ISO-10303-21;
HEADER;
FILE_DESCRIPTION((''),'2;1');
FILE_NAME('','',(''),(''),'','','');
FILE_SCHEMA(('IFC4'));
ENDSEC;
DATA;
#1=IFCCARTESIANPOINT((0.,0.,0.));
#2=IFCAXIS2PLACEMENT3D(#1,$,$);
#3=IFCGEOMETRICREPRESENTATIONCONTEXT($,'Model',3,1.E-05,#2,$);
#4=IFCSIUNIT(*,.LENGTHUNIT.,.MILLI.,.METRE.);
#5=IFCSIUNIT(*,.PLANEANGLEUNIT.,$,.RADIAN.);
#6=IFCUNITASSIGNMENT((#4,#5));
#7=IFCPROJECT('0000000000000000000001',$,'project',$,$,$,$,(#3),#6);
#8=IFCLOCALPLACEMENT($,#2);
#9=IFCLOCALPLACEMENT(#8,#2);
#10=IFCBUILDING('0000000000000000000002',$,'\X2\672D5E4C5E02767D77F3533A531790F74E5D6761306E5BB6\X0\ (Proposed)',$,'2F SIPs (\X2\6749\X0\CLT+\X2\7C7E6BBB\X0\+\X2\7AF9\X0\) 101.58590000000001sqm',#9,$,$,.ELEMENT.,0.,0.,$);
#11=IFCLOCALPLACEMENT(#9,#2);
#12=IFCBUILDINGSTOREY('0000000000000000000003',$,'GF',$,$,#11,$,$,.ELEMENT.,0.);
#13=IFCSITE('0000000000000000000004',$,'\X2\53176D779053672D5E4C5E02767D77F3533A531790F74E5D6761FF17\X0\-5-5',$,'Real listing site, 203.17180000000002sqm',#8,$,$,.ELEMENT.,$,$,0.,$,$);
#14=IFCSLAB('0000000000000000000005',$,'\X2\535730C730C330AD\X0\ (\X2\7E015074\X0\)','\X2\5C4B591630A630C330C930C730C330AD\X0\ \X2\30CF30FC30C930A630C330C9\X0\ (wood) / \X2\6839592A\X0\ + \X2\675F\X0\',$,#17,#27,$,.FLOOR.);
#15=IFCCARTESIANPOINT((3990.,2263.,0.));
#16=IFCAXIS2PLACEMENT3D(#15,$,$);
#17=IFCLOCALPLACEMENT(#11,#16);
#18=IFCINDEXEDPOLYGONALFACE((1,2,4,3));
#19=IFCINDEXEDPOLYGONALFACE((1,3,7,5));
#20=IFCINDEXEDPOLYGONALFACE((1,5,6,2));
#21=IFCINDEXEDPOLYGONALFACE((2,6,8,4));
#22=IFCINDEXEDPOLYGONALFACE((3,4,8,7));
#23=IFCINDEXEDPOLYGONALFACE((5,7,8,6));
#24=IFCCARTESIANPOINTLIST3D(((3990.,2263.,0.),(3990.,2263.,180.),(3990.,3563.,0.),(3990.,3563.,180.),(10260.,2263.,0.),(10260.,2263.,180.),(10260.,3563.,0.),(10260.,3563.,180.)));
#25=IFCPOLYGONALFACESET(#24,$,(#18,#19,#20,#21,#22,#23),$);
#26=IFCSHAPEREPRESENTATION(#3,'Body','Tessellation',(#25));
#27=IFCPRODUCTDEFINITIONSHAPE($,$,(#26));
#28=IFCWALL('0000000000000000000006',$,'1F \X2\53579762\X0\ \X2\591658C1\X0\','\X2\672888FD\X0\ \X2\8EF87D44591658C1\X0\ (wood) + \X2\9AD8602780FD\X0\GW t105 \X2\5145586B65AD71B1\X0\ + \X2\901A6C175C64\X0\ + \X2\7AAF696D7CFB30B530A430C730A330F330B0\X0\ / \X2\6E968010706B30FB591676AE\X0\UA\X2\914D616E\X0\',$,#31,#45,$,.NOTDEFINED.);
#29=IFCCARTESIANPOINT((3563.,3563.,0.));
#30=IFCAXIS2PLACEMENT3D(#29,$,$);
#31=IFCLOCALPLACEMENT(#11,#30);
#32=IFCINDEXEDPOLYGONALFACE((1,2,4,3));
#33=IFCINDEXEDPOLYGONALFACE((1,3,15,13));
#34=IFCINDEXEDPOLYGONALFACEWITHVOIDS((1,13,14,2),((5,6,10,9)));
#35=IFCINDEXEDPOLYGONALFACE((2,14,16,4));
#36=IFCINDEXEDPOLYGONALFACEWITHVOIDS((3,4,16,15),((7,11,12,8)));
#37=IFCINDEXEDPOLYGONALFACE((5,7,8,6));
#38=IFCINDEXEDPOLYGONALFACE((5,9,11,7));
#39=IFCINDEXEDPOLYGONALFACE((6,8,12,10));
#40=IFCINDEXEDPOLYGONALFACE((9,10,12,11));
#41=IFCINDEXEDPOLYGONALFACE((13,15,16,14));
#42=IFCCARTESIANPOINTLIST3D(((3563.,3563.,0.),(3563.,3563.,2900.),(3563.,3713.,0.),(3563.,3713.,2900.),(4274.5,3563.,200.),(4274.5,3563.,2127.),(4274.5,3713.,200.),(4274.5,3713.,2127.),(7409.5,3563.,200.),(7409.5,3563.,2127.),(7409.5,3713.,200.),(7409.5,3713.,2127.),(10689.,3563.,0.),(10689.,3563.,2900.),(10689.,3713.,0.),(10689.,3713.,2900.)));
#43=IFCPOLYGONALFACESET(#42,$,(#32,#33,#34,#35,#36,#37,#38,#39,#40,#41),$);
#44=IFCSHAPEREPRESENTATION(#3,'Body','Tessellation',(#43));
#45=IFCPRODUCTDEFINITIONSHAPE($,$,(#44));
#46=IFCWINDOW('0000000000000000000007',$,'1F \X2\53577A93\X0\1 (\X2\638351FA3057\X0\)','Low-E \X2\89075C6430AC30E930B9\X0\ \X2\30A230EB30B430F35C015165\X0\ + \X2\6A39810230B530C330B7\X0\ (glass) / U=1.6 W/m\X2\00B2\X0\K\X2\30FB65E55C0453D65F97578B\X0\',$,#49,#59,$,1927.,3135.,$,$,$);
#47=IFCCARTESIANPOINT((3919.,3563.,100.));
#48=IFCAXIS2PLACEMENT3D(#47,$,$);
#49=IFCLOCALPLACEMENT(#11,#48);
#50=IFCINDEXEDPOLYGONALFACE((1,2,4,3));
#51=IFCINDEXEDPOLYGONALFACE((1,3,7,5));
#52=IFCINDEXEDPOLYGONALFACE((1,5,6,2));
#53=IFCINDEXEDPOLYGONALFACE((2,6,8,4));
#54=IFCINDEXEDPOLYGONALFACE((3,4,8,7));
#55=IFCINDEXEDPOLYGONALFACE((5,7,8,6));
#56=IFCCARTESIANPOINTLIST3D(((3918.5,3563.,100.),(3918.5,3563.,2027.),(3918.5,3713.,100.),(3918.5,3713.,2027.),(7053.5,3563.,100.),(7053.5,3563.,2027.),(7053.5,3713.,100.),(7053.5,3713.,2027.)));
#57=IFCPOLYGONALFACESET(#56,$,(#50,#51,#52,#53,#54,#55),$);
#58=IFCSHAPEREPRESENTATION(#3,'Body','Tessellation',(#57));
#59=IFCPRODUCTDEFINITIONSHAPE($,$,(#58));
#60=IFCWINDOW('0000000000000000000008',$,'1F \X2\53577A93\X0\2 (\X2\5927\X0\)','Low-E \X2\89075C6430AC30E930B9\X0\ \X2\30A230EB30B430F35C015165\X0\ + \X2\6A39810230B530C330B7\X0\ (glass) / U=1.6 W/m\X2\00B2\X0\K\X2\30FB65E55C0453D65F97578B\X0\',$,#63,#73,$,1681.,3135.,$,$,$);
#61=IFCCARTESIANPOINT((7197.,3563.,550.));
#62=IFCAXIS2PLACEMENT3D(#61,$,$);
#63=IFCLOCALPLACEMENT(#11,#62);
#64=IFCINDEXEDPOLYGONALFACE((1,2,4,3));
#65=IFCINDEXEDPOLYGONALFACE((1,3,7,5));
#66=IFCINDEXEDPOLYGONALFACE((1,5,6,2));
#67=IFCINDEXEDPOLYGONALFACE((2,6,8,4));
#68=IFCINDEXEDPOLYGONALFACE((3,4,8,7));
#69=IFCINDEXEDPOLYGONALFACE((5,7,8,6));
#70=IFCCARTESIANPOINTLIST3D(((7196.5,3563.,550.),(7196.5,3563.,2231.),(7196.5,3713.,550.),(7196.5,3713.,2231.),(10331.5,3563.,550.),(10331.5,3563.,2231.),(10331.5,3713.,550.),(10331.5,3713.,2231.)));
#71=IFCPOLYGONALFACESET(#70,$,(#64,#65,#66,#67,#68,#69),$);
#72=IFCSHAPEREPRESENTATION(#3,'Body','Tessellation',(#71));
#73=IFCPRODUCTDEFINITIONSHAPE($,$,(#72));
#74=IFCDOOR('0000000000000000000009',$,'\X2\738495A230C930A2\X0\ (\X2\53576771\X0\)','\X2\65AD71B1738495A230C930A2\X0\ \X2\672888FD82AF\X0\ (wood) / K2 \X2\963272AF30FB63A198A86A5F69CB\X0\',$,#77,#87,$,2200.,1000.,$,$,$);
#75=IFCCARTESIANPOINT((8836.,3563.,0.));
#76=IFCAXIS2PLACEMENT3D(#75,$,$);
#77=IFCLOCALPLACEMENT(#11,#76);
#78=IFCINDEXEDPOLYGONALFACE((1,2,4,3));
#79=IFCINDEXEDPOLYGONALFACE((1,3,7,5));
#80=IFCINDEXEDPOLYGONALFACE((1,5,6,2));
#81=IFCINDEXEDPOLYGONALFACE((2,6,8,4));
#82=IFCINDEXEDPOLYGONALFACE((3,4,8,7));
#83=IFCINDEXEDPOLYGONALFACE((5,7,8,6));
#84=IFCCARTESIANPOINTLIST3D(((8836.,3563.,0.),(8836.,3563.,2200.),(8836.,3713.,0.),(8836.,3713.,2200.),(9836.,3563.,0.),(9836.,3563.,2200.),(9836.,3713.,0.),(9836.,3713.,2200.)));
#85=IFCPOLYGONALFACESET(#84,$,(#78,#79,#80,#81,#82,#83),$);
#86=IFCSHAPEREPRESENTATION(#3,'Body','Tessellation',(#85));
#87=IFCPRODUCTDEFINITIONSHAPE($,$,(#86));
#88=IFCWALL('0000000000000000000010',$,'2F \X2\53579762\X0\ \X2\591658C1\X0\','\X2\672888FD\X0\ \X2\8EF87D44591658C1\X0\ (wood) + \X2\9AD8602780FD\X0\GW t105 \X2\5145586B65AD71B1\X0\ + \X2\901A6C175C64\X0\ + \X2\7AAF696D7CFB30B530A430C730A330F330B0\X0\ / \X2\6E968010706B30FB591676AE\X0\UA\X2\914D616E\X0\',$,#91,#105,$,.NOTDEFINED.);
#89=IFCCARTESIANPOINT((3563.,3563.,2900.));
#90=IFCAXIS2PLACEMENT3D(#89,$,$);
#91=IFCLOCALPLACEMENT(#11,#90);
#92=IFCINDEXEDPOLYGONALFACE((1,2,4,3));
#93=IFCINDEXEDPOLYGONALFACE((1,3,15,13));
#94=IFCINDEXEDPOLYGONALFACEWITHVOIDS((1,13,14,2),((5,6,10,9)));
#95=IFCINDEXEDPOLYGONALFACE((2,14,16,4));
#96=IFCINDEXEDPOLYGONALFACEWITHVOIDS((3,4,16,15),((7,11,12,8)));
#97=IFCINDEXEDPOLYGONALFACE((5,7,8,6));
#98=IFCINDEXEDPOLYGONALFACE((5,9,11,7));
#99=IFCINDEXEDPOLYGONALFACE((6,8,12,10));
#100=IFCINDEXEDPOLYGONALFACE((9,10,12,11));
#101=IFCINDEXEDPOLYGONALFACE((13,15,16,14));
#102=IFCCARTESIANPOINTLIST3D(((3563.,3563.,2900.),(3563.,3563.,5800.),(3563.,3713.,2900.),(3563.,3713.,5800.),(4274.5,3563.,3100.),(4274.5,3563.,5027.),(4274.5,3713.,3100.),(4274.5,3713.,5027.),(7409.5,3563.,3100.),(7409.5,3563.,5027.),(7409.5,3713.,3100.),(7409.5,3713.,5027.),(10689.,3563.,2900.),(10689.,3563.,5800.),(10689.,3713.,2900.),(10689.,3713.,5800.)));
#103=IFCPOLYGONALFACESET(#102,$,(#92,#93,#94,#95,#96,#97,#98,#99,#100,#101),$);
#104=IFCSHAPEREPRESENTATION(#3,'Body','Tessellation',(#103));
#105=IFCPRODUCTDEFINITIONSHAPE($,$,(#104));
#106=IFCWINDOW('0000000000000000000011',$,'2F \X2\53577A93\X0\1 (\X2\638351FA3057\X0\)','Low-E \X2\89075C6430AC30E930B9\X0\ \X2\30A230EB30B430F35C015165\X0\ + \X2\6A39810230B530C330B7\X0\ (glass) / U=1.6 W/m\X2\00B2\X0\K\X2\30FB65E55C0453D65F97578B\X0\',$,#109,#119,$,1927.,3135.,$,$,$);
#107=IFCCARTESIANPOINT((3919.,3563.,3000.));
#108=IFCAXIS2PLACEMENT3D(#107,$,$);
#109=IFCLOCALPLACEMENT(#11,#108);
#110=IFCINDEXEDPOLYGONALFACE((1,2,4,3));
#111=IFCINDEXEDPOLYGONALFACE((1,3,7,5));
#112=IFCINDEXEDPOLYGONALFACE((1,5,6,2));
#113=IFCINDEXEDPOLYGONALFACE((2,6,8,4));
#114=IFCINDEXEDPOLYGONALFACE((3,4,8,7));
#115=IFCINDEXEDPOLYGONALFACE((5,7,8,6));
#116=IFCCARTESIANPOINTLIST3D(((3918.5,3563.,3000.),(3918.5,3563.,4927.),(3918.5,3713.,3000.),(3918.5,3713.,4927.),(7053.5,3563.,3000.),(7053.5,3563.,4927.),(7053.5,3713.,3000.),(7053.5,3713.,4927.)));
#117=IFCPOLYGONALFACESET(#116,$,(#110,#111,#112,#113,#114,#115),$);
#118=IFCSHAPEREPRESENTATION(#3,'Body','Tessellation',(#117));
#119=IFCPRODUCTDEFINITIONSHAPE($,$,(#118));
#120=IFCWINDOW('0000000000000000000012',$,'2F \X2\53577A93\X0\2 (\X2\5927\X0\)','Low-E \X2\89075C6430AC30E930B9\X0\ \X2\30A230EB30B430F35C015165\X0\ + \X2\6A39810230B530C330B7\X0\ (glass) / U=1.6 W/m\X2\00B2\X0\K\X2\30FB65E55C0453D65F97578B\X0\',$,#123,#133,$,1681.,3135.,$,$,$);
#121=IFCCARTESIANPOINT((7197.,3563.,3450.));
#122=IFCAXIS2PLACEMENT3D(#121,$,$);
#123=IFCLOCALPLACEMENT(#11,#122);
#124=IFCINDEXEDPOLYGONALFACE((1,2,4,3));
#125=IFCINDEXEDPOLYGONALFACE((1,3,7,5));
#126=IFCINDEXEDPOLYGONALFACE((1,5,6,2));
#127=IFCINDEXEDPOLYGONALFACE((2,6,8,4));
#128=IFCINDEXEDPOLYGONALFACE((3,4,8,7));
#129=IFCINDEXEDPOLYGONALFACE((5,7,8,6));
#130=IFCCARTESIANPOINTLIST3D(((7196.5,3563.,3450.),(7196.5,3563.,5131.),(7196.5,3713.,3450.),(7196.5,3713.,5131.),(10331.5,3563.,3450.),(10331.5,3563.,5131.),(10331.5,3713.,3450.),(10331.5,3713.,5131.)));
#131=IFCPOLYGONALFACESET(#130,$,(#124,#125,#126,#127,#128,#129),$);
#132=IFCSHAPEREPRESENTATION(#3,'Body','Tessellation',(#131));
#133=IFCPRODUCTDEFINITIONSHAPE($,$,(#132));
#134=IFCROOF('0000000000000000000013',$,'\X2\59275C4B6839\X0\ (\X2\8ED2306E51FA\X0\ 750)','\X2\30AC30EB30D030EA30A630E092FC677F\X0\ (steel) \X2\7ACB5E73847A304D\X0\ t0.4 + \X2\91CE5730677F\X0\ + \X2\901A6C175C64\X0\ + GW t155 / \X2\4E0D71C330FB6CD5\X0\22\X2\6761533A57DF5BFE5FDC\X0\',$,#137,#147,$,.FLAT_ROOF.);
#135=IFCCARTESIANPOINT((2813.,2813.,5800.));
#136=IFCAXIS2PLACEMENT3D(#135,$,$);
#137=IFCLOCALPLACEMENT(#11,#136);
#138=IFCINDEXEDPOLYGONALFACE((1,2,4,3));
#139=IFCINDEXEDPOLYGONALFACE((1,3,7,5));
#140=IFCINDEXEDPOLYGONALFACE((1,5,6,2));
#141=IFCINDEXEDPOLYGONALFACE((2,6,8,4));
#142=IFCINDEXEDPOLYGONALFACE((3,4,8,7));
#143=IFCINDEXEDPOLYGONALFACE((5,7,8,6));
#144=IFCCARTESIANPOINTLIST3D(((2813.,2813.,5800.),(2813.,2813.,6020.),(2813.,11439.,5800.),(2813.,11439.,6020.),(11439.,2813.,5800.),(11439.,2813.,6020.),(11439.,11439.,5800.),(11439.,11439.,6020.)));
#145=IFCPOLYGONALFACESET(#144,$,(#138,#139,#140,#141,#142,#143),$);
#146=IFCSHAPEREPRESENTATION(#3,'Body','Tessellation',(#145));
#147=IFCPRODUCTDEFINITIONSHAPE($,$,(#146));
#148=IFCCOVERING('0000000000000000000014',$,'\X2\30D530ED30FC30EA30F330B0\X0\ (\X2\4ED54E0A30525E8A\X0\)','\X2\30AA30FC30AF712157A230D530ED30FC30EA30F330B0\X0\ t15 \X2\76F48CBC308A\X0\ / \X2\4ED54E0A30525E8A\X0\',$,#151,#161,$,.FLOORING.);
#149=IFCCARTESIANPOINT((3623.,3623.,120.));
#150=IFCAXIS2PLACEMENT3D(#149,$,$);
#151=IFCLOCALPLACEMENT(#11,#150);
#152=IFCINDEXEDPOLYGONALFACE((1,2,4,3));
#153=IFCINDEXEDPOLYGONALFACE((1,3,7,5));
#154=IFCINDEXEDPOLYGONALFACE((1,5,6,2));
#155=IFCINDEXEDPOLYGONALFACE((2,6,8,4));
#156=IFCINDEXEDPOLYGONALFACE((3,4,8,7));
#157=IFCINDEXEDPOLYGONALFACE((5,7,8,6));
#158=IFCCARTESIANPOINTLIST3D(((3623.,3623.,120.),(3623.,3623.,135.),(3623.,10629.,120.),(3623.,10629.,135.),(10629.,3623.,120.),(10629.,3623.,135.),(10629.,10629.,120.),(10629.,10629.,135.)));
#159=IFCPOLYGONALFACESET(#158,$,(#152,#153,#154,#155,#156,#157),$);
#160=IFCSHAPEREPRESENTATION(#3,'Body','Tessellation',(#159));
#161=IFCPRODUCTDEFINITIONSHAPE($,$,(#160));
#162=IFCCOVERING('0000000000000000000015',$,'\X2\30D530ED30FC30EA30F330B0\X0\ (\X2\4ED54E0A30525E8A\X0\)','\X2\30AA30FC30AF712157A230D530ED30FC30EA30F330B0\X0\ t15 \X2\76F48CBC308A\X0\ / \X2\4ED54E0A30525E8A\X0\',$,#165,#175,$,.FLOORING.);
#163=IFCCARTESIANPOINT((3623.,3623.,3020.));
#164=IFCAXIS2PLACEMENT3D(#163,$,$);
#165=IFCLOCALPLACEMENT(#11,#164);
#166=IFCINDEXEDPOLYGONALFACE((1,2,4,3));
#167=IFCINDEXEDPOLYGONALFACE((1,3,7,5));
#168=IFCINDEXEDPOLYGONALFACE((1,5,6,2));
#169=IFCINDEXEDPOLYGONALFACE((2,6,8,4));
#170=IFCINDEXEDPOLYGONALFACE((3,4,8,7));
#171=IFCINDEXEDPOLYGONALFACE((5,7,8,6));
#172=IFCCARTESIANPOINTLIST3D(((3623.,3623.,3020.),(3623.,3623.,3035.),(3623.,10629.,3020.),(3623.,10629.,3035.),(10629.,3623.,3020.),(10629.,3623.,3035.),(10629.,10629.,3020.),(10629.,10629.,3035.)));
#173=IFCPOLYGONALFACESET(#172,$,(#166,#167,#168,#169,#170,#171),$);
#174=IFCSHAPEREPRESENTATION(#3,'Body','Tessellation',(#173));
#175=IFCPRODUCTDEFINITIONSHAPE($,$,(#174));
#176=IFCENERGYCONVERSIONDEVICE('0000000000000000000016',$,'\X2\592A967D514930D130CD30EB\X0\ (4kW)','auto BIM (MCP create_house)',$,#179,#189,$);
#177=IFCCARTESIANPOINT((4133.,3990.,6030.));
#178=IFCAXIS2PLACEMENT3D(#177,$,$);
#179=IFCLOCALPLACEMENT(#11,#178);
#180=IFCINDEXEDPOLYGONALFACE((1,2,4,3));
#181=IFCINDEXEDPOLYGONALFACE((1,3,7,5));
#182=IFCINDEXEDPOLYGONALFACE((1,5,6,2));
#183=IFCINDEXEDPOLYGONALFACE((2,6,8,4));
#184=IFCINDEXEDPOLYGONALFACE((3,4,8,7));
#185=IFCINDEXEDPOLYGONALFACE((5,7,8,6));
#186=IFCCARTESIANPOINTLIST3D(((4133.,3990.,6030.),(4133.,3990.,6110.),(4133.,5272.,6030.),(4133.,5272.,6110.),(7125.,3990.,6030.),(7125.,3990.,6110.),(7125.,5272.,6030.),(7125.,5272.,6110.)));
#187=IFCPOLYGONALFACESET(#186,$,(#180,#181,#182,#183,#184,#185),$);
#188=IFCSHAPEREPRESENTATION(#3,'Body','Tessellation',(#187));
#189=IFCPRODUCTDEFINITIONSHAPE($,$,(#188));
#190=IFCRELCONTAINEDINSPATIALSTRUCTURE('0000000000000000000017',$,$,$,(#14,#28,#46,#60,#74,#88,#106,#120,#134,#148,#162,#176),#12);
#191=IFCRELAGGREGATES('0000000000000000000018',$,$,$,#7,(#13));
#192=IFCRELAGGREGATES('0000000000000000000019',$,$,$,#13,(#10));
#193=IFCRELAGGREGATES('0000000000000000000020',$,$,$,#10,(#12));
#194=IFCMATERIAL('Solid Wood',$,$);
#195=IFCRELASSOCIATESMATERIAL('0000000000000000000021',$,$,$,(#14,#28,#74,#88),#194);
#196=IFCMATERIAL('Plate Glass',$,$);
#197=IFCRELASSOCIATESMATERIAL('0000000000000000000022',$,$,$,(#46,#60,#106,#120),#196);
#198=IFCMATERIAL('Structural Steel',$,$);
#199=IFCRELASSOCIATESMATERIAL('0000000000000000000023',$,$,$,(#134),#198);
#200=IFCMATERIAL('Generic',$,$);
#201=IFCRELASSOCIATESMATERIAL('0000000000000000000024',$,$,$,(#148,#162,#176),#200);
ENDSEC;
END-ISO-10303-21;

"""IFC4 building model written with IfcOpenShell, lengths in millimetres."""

from ifc_helpers import new_model, si_unit, frame, frame_2d, origin, place, context, project, spatial, rectangle, extrude, material, element, fill, save


model = new_model("IFC4")

# Units and contexts
model_context = context("Model", 3, precision=1e-05, world=origin())
ifc_project = project(units=[si_unit("LENGTHUNIT", "METRE", prefix="MILLI"), si_unit("PLANEANGLEUNIT", "RADIAN")], contexts=[model_context])

# Site, building, storey
site_placement = place(None, origin())
site = spatial("IfcSite", under=ifc_project, at=site_placement, Name="北海道札幌市白石区北郷九条７-5-5", ObjectType="Real listing site, 203.17180000000002sqm", CompositionType="ELEMENT", RefElevation=0.0)
building_placement = place(site_placement, origin())
building = spatial("IfcBuilding", under=site, at=building_placement, Name="札幌市白石区北郷九条の家 (Proposed)", ObjectType="2F SIPs (杉CLT+籾殻+竹) 101.58590000000001sqm", CompositionType="ELEMENT", ElevationOfRefHeight=0.0, ElevationOfTerrain=0.0)
storey_placement = place(building_placement, origin())
storey = spatial("IfcBuildingStorey", under=building, at=storey_placement, Name="GF", CompositionType="ELEMENT", Elevation=0.0)

# Slab
ifc_material_1 = material(Name="Solid Wood")
slab_1_placement = place(storey_placement, frame((3990.0, 2263.0, 0.0)))
element("IfcSlab", 1, at=slab_1_placement, inside=storey, material=ifc_material_1, Name="南デッキ (縁側)", Description="屋外ウッドデッキ ハードウッド (wood) / 根太 + 束", PredefinedType="FLOOR", context=model_context, shape_type="SweptSolid", body=[
    extrude(rectangle(XDim=6270.0, YDim=1300.0, at=frame_2d((3135.0, 650.0))), frame((3990.0, 2263.0, 0.0)), (0.0, 0.0, 1.0), 180.0),
])

# Wall, openings, windows, door
wall_1_placement = place(storey_placement, frame((3563.0, 3563.0, 0.0)))
wall_1 = element("IfcWall", 2, at=wall_1_placement, inside=storey, material=ifc_material_1, Name="1F 南面 外壁", Description="木製 軸組外壁 (wood) + 高性能GW t105 充填断熱 + 通気層 + 窯業系サイディング / 準耐火・外皮UA配慮", PredefinedType="NOTDEFINED", context=model_context, shape_type="SweptSolid", body=[
    extrude(rectangle(XDim=7126.0, YDim=150.0, at=frame_2d((3563.0, 75.0))), frame((3563.0, 3563.0, 0.0)), (0.0, 0.0, 1.0), 2900.0),
])
opening_1_placement = place(storey_placement, frame((3919.0, 3563.0, 100.0)))
opening_1 = element("IfcOpeningElement", 3, at=opening_1_placement, cuts=wall_1, PredefinedType="NOTDEFINED", context=model_context, shape_type="SweptSolid", body=[
    extrude(rectangle(XDim=3135.0, YDim=150.0, at=frame_2d((1567.0, 75.0))), frame((3919.0, 3563.0, 100.0)), (0.0, 0.0, 1.0), 1927.0),
])
opening_2_placement = place(storey_placement, frame((7197.0, 3563.0, 550.0)))
opening_2 = element("IfcOpeningElement", 4, at=opening_2_placement, cuts=wall_1, PredefinedType="NOTDEFINED", context=model_context, shape_type="SweptSolid", body=[
    extrude(rectangle(XDim=3135.0, YDim=150.0, at=frame_2d((1567.0, 75.0))), frame((7197.0, 3563.0, 550.0)), (0.0, 0.0, 1.0), 1681.0),
])
opening_3_placement = place(storey_placement, frame((8836.0, 3563.0, 0.0)))
opening_3 = element("IfcOpeningElement", 5, at=opening_3_placement, cuts=wall_1, PredefinedType="NOTDEFINED", context=model_context, shape_type="SweptSolid", body=[
    extrude(rectangle(XDim=1000.0, YDim=150.0, at=frame_2d((500.0, 75.0))), frame((8836.0, 3563.0, 0.0)), (0.0, 0.0, 1.0), 2200.0),
])
ifc_material_2 = material(Name="Plate Glass")
window_1_placement = place(storey_placement, frame((3919.0, 3563.0, 100.0)))
window_1 = element("IfcWindow", 6, at=window_1_placement, inside=storey, material=ifc_material_2, Name="1F 南窓1 (掃出し)", Description="Low-E 複層ガラス アルゴン封入 + 樹脂サッシ (glass) / U=1.6 W/m²K・日射取得型", OverallHeight=1927.0, OverallWidth=3135.0, context=model_context, shape_type="SweptSolid", body=[
    extrude(rectangle(XDim=3135.0, YDim=150.0, at=frame_2d((1567.0, 75.0))), frame((3919.0, 3563.0, 100.0)), (0.0, 0.0, 1.0), 1927.0),
])
fill(opening_1, window_1)
window_2_placement = place(storey_placement, frame((7197.0, 3563.0, 550.0)))
window_2 = element("IfcWindow", 7, at=window_2_placement, inside=storey, material=ifc_material_2, Name="1F 南窓2 (大)", Description="Low-E 複層ガラス アルゴン封入 + 樹脂サッシ (glass) / U=1.6 W/m²K・日射取得型", OverallHeight=1681.0, OverallWidth=3135.0, context=model_context, shape_type="SweptSolid", body=[
    extrude(rectangle(XDim=3135.0, YDim=150.0, at=frame_2d((1567.0, 75.0))), frame((7197.0, 3563.0, 550.0)), (0.0, 0.0, 1.0), 1681.0),
])
fill(opening_2, window_2)
door_placement = place(storey_placement, frame((8836.0, 3563.0, 0.0)))
door = element("IfcDoor", 8, at=door_placement, inside=storey, material=ifc_material_1, Name="玄関ドア (南東)", Description="断熱玄関ドア 木製芯 (wood) / K2 防犯・採風機構", OverallHeight=2200.0, OverallWidth=1000.0, context=model_context, shape_type="SweptSolid", body=[
    extrude(rectangle(XDim=1000.0, YDim=150.0, at=frame_2d((500.0, 75.0))), frame((8836.0, 3563.0, 0.0)), (0.0, 0.0, 1.0), 2200.0),
])
fill(opening_3, door)

# Wall, openings, windows
wall_2_placement = place(storey_placement, frame((3563.0, 3563.0, 2900.0)))
wall_2 = element("IfcWall", 9, at=wall_2_placement, inside=storey, material=ifc_material_1, Name="2F 南面 外壁", Description="木製 軸組外壁 (wood) + 高性能GW t105 充填断熱 + 通気層 + 窯業系サイディング / 準耐火・外皮UA配慮", PredefinedType="NOTDEFINED", context=model_context, shape_type="SweptSolid", body=[
    extrude(rectangle(XDim=7126.0, YDim=150.0, at=frame_2d((3563.0, 75.0))), frame((3563.0, 3563.0, 2900.0)), (0.0, 0.0, 1.0), 2900.0),
])
opening_4_placement = place(storey_placement, frame((3919.0, 3563.0, 3000.0)))
opening_4 = element("IfcOpeningElement", 10, at=opening_4_placement, cuts=wall_2, PredefinedType="NOTDEFINED", context=model_context, shape_type="SweptSolid", body=[
    extrude(rectangle(XDim=3135.0, YDim=150.0, at=frame_2d((1567.0, 75.0))), frame((3919.0, 3563.0, 3000.0)), (0.0, 0.0, 1.0), 1927.0),
])
opening_5_placement = place(storey_placement, frame((7197.0, 3563.0, 3450.0)))
opening_5 = element("IfcOpeningElement", 11, at=opening_5_placement, cuts=wall_2, PredefinedType="NOTDEFINED", context=model_context, shape_type="SweptSolid", body=[
    extrude(rectangle(XDim=3135.0, YDim=150.0, at=frame_2d((1567.0, 75.0))), frame((7197.0, 3563.0, 3450.0)), (0.0, 0.0, 1.0), 1681.0),
])
window_3_placement = place(storey_placement, frame((3919.0, 3563.0, 3000.0)))
window_3 = element("IfcWindow", 12, at=window_3_placement, inside=storey, material=ifc_material_2, Name="2F 南窓1 (掃出し)", Description="Low-E 複層ガラス アルゴン封入 + 樹脂サッシ (glass) / U=1.6 W/m²K・日射取得型", OverallHeight=1927.0, OverallWidth=3135.0, context=model_context, shape_type="SweptSolid", body=[
    extrude(rectangle(XDim=3135.0, YDim=150.0, at=frame_2d((1567.0, 75.0))), frame((3919.0, 3563.0, 3000.0)), (0.0, 0.0, 1.0), 1927.0),
])
fill(opening_4, window_3)
window_4_placement = place(storey_placement, frame((7197.0, 3563.0, 3450.0)))
window_4 = element("IfcWindow", 13, at=window_4_placement, inside=storey, material=ifc_material_2, Name="2F 南窓2 (大)", Description="Low-E 複層ガラス アルゴン封入 + 樹脂サッシ (glass) / U=1.6 W/m²K・日射取得型", OverallHeight=1681.0, OverallWidth=3135.0, context=model_context, shape_type="SweptSolid", body=[
    extrude(rectangle(XDim=3135.0, YDim=150.0, at=frame_2d((1567.0, 75.0))), frame((7197.0, 3563.0, 3450.0)), (0.0, 0.0, 1.0), 1681.0),
])
fill(opening_5, window_4)

# Roof
ifc_material_3 = material(Name="Structural Steel")
roof_placement = place(storey_placement, frame((2813.0, 2813.0, 5800.0)))
element("IfcRoof", 14, at=roof_placement, inside=storey, material=ifc_material_3, Name="大屋根 (軒の出 750)", Description="ガルバリウム鋼板 (steel) 立平葺き t0.4 + 野地板 + 通気層 + GW t155 / 不燃・法22条区域対応", PredefinedType="FLAT_ROOF", context=model_context, shape_type="SweptSolid", body=[
    extrude(rectangle(XDim=8626.0, YDim=8626.0, at=frame_2d((4313.0, 4313.0))), frame((2813.0, 2813.0, 5800.0)), (0.0, 0.0, 1.0), 220.0),
])

# Coverings
ifc_material_4 = material(Name="Generic")
covering_1_placement = place(storey_placement, frame((3623.0, 3623.0, 120.0)))
element("IfcCovering", 15, at=covering_1_placement, inside=storey, material=ifc_material_4, Name="フローリング (仕上げ床)", Description="オーク無垢フローリング t15 直貼り / 仕上げ床", PredefinedType="FLOORING", context=model_context, shape_type="SweptSolid", body=[
    extrude(rectangle(XDim=7006.0, YDim=7006.0, at=frame_2d((3503.0, 3503.0))), frame((3623.0, 3623.0, 120.0)), (0.0, 0.0, 1.0), 15.0),
])
covering_2_placement = place(storey_placement, frame((3623.0, 3623.0, 3020.0)))
element("IfcCovering", 16, at=covering_2_placement, inside=storey, material=ifc_material_4, Name="フローリング (仕上げ床)", Description="オーク無垢フローリング t15 直貼り / 仕上げ床", PredefinedType="FLOORING", context=model_context, shape_type="SweptSolid", body=[
    extrude(rectangle(XDim=7006.0, YDim=7006.0, at=frame_2d((3503.0, 3503.0))), frame((3623.0, 3623.0, 3020.0)), (0.0, 0.0, 1.0), 15.0),
])

# Energy conversion device
energy_conversion_device_placement = place(storey_placement, frame((4133.0, 3990.0, 6030.0)))
element("IfcEnergyConversionDevice", 17, at=energy_conversion_device_placement, inside=storey, material=ifc_material_4, Name="太陽光パネル (4kW)", Description="auto BIM (MCP create_house)", context=model_context, shape_type="SweptSolid", body=[
    extrude(rectangle(XDim=2992.0, YDim=1282.0, at=frame_2d((1496.0, 641.0))), frame((4133.0, 3990.0, 6030.0)), (0.0, 0.0, 1.0), 80.0),
])

save(model, "model.ifc")
